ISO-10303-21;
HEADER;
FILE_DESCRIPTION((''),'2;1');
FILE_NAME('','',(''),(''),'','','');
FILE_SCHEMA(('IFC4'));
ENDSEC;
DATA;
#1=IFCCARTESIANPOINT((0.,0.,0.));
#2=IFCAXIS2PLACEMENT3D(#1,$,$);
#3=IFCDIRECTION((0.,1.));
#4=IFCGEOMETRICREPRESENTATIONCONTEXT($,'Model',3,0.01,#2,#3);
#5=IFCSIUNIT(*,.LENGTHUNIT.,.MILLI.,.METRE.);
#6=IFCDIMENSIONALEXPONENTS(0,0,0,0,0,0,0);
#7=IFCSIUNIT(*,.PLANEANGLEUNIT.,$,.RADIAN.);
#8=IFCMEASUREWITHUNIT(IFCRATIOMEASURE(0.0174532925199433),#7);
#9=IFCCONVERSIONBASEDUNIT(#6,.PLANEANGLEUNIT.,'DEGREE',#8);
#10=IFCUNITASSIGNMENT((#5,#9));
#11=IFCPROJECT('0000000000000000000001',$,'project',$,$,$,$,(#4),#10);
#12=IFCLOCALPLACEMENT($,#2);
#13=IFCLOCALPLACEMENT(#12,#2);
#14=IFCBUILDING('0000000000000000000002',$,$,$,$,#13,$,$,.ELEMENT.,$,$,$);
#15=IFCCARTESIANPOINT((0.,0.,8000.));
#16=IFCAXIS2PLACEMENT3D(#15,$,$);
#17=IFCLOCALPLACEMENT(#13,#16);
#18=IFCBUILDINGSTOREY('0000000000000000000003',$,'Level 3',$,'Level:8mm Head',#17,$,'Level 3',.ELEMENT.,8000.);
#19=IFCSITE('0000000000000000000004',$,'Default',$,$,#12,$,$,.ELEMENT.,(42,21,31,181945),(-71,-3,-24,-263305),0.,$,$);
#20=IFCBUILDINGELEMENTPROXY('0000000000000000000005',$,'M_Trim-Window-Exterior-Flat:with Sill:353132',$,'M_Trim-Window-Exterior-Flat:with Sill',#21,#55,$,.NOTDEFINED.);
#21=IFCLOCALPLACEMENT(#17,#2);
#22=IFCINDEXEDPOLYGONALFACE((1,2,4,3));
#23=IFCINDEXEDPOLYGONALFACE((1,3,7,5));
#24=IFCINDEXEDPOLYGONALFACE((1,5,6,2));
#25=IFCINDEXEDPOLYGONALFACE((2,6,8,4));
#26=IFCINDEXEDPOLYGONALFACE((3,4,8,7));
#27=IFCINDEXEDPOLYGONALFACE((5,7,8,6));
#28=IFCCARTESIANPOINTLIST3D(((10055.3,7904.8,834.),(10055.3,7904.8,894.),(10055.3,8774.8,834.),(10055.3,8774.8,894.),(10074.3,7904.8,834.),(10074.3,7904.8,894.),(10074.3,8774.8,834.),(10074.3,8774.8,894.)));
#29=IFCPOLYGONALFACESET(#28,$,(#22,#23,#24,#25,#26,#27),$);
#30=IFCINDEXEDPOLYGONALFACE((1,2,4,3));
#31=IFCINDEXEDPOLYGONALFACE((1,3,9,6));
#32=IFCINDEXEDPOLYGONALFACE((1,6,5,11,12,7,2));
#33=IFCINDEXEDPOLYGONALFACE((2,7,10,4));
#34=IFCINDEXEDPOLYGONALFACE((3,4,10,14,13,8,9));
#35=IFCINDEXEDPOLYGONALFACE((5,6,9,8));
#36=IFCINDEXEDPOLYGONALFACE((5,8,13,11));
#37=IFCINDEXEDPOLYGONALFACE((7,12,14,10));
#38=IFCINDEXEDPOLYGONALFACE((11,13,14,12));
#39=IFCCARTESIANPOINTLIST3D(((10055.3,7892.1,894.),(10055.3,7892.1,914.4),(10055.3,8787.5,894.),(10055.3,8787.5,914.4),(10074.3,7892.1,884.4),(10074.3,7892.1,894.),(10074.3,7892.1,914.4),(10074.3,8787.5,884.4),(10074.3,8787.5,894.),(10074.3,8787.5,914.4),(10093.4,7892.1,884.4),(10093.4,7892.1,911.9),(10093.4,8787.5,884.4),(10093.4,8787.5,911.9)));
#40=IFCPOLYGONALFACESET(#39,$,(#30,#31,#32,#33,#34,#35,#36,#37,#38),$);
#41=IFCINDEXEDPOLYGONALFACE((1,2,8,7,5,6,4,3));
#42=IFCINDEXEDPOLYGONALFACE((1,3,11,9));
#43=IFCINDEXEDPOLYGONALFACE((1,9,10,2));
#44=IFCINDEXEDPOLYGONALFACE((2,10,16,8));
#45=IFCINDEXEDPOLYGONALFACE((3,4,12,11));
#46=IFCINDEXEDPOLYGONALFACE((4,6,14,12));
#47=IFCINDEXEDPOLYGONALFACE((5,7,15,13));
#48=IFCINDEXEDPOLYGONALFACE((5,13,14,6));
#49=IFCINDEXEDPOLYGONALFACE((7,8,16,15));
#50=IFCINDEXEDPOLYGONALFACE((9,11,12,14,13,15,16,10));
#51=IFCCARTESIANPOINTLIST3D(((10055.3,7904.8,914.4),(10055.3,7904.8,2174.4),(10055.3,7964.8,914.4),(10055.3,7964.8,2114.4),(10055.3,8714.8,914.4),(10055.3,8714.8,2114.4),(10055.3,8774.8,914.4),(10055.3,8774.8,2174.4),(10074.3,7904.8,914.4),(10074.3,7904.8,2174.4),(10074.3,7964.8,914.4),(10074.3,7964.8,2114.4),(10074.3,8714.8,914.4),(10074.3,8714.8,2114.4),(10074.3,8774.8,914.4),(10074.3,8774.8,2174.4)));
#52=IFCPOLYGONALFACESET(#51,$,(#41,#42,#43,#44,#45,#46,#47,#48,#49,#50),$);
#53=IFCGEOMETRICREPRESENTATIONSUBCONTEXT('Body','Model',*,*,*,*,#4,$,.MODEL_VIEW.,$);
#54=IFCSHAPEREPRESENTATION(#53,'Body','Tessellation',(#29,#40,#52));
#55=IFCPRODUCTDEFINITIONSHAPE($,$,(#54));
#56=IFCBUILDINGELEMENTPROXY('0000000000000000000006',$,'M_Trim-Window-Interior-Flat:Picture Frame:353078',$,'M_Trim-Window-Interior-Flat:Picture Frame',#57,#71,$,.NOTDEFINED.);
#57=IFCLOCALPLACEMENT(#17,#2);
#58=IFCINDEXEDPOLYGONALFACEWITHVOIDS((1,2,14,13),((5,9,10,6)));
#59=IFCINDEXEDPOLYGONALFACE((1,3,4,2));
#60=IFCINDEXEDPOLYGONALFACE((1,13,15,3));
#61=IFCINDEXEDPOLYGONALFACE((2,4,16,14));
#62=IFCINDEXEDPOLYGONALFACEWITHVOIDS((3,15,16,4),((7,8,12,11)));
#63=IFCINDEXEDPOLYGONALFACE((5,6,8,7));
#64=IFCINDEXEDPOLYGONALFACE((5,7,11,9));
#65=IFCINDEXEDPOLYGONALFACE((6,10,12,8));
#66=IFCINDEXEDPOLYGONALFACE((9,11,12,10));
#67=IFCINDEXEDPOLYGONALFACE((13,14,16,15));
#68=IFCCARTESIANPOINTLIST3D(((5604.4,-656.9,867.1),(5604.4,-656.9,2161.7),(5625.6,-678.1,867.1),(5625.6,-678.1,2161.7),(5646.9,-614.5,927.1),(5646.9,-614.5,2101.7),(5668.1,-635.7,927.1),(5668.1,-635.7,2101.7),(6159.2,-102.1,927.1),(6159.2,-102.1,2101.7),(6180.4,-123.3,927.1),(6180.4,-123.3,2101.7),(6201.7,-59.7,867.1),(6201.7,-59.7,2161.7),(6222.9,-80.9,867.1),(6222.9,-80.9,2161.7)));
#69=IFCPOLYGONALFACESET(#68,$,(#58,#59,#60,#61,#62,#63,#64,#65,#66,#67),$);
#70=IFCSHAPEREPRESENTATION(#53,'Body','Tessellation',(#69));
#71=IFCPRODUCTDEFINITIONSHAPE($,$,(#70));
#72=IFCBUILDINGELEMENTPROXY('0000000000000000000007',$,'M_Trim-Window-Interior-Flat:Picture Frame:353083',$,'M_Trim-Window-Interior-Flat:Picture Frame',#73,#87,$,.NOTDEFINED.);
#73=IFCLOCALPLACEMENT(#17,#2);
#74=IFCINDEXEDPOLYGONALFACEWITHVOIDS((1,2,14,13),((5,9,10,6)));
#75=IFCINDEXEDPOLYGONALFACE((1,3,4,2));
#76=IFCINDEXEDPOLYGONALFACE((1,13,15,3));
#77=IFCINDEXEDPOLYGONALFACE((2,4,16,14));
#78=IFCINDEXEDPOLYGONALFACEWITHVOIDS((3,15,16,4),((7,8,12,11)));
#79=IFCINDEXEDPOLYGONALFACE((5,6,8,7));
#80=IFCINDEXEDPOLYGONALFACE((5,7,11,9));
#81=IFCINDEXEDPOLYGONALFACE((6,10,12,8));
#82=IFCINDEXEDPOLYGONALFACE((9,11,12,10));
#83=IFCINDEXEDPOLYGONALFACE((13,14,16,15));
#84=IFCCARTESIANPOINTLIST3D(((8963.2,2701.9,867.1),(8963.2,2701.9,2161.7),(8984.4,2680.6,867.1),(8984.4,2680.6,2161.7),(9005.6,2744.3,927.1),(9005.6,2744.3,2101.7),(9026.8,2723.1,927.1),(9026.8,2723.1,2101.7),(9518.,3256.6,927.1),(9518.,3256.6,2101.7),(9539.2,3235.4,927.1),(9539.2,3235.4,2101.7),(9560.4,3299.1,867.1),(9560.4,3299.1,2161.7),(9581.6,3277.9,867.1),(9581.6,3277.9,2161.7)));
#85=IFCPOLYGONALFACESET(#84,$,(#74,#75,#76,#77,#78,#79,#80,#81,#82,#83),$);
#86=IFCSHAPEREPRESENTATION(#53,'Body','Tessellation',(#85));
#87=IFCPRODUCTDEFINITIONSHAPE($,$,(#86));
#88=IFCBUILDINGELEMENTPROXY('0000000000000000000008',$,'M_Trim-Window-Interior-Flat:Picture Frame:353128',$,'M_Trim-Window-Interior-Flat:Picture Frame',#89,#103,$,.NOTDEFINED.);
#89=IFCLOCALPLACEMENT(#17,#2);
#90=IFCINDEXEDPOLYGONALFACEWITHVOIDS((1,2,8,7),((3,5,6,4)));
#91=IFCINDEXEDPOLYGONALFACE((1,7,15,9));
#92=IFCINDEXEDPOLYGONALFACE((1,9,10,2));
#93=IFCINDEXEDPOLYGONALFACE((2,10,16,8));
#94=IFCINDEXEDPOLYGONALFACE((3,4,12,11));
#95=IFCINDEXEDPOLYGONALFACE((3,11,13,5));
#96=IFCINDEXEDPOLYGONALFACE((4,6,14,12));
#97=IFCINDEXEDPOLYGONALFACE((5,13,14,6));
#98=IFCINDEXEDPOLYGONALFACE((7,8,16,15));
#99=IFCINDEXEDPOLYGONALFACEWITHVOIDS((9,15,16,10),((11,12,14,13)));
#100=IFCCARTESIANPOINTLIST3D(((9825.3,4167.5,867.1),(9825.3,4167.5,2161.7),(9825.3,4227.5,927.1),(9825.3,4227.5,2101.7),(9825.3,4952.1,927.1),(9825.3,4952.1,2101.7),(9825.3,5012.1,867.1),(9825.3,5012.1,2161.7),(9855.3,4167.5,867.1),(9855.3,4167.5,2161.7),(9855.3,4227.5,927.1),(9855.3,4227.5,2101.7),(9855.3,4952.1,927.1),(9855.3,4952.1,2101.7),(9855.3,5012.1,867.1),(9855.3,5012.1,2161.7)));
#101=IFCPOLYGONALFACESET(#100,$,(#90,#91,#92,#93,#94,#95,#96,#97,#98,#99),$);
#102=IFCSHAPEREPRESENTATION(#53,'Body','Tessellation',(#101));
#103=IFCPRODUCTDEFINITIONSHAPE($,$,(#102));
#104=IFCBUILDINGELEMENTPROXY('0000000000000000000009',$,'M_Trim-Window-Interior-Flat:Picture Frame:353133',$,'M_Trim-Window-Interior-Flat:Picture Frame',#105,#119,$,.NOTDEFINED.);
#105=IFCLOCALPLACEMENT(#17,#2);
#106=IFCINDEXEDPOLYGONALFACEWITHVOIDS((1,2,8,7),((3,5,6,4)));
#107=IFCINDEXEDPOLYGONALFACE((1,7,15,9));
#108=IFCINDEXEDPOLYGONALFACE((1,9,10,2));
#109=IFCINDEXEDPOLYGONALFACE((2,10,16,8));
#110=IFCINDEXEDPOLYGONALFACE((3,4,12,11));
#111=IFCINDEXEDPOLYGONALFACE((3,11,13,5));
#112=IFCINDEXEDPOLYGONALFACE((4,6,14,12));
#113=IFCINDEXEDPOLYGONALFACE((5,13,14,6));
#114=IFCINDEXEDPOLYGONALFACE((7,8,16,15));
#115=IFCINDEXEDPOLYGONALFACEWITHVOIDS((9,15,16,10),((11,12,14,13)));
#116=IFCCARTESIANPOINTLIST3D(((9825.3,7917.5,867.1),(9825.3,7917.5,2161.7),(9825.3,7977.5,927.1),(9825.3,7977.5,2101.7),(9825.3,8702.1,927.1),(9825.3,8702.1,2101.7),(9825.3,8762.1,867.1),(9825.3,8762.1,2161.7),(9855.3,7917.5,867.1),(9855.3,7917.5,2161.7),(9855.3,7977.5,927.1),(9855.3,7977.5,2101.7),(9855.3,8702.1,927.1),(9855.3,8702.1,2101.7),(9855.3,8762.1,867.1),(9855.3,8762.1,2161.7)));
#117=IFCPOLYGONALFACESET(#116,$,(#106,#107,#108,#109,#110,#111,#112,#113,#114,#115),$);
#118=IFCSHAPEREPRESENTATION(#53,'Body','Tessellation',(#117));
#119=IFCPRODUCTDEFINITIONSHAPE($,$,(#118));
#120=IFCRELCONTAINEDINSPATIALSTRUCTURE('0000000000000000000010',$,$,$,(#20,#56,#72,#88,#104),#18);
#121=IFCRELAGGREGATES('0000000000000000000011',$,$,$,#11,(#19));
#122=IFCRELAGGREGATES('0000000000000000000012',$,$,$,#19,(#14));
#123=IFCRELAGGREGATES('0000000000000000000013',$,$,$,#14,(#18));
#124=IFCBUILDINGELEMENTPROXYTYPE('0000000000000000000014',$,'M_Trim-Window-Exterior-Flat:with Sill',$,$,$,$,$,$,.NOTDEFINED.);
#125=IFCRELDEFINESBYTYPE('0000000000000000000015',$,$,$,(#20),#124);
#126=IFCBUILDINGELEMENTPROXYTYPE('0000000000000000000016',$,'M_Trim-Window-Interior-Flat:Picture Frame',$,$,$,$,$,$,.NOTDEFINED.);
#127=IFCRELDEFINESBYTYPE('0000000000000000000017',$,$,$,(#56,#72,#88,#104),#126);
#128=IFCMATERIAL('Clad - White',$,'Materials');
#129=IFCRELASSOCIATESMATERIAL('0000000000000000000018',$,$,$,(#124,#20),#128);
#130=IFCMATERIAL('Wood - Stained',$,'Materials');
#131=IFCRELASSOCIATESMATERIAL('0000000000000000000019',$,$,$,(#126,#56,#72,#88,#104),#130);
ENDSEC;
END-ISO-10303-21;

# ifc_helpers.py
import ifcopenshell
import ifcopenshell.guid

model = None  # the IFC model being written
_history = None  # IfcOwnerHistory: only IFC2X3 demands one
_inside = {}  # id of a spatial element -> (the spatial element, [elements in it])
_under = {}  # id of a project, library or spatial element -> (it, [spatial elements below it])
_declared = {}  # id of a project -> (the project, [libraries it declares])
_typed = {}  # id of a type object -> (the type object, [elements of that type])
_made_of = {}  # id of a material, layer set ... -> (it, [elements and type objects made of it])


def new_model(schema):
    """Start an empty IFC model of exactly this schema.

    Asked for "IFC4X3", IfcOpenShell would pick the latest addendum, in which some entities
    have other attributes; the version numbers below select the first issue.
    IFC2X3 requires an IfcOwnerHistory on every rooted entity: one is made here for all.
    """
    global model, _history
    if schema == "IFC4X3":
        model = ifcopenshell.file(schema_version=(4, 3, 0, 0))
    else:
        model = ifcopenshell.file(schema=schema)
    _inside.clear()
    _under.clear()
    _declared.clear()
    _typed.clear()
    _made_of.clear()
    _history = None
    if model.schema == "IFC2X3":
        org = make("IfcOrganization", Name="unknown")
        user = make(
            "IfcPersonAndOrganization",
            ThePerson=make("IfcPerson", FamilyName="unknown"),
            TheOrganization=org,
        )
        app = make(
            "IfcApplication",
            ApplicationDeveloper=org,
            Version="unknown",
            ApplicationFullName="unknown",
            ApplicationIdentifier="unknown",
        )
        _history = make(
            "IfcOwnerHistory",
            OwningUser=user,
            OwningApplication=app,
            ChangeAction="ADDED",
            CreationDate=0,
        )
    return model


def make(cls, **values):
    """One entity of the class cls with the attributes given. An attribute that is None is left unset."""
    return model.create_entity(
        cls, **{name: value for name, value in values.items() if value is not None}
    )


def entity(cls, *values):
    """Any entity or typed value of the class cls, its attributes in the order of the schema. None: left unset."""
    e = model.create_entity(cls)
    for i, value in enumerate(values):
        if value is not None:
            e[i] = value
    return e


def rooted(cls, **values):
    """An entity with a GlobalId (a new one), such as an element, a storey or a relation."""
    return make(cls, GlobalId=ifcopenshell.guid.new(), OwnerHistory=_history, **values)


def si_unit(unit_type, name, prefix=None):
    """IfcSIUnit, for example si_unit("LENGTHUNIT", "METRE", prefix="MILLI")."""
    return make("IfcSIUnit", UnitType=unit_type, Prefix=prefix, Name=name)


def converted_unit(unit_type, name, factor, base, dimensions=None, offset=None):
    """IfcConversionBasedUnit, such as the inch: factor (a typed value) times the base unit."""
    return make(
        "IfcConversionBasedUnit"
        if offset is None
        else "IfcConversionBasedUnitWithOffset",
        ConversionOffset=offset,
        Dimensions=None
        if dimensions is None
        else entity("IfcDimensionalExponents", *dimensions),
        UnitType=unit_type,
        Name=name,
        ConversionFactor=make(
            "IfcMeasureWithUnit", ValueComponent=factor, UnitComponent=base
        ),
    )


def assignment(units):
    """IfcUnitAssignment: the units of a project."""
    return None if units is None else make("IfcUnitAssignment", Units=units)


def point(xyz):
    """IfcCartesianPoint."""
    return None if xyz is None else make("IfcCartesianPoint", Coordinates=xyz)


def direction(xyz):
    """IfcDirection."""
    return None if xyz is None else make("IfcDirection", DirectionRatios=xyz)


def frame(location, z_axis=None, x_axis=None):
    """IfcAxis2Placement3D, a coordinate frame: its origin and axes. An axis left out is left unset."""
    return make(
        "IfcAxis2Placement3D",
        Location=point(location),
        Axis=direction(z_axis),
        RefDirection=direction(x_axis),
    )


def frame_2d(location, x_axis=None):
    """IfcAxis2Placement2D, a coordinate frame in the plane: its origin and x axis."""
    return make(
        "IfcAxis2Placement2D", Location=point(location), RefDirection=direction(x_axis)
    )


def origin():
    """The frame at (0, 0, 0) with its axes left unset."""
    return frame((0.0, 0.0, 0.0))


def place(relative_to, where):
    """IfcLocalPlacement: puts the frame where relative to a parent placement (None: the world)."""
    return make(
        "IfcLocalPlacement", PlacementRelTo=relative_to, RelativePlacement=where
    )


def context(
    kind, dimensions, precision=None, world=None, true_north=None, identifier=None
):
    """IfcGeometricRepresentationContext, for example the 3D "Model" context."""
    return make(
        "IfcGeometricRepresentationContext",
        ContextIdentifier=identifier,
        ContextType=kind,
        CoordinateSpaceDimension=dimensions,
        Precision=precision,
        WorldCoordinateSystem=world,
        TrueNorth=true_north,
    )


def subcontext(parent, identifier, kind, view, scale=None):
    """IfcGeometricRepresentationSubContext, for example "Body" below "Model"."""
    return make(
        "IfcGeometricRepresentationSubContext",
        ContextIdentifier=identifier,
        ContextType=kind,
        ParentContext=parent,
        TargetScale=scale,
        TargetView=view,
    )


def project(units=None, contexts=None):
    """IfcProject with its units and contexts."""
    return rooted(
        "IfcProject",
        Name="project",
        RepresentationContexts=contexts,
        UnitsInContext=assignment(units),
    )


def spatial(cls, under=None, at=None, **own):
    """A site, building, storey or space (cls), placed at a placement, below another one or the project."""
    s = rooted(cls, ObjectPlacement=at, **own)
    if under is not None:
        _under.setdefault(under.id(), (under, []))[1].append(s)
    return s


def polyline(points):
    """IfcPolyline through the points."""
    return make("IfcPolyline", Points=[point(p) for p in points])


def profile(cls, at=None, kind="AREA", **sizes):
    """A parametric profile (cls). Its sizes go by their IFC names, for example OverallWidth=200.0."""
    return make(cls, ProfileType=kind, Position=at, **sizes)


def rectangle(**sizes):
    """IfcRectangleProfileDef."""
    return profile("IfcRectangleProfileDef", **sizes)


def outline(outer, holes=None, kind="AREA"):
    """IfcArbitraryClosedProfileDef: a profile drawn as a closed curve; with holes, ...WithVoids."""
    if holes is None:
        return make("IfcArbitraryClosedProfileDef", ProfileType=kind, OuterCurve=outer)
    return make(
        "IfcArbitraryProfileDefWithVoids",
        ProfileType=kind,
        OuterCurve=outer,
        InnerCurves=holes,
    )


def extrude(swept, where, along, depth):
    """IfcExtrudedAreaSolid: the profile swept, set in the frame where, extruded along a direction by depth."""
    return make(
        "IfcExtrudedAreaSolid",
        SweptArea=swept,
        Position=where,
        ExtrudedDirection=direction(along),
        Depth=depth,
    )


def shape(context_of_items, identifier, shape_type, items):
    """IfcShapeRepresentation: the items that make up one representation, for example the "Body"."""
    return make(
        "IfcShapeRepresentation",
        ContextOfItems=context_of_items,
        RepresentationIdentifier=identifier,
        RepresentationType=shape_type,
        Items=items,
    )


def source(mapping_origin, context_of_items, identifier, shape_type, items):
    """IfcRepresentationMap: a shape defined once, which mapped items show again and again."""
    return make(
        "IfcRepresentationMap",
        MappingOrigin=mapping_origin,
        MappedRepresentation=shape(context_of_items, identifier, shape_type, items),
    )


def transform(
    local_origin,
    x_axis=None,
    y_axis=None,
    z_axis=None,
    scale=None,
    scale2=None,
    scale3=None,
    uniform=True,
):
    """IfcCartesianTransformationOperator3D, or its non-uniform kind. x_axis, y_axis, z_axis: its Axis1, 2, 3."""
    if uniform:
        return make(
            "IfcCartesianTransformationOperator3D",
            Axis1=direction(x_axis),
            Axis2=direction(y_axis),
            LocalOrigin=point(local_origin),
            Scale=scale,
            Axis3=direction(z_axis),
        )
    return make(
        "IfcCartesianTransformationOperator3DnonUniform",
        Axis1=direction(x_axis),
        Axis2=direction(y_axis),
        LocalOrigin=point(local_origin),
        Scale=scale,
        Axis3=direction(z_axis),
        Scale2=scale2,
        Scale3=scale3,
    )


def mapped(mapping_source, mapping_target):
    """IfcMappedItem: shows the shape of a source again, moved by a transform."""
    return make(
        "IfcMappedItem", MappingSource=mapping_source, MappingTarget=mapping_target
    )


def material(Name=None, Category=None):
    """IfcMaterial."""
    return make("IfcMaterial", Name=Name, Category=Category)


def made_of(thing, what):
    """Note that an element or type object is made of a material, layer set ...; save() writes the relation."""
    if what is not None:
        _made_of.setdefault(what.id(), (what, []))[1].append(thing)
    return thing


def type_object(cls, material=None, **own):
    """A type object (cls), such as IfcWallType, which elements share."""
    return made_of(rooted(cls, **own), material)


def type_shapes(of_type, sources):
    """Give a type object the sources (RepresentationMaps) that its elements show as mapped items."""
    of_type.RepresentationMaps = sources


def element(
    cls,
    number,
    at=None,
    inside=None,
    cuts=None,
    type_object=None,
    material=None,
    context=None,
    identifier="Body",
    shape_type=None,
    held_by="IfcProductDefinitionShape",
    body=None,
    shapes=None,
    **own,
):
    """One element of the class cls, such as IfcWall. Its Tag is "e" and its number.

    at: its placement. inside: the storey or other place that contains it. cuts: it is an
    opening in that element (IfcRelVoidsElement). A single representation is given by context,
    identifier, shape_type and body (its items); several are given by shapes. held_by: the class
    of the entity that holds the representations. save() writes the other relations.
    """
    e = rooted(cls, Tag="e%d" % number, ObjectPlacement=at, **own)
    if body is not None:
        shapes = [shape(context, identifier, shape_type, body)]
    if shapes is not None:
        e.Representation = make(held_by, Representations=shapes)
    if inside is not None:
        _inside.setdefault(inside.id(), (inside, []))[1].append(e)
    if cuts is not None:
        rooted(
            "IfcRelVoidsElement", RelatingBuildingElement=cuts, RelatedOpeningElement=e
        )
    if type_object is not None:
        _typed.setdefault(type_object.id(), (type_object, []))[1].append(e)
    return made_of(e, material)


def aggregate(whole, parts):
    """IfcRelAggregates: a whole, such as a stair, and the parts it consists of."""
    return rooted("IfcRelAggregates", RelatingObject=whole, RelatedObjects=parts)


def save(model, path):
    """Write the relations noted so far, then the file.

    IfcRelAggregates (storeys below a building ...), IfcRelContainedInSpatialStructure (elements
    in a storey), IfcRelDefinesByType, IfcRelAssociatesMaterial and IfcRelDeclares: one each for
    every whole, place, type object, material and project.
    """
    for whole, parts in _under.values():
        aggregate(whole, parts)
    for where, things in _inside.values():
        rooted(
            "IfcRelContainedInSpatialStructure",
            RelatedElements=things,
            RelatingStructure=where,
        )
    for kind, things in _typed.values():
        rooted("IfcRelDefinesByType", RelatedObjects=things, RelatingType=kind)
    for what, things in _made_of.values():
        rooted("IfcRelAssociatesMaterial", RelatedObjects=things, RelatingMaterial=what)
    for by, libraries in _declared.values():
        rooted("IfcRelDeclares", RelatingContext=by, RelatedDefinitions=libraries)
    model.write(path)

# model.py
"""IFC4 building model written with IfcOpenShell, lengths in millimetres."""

from ifc_helpers import new_model, entity, si_unit, converted_unit, direction, frame, frame_2d, origin, place, context, subcontext, project, spatial, polyline, rectangle, outline, extrude, source, transform, mapped, material, type_object, type_shapes, element, save


model = new_model("IFC4")

# Units and contexts
model_context = context("Model", 3, precision=0.01, world=origin(), true_north=direction((0.0, 1.0)))
body_context = subcontext(model_context, "Body", "Model", "MODEL_VIEW")
ifc_project = project(units=[si_unit("LENGTHUNIT", "METRE", prefix="MILLI"), converted_unit("PLANEANGLEUNIT", "DEGREE", entity("IfcRatioMeasure", 0.0174532925199433), si_unit("PLANEANGLEUNIT", "RADIAN"), dimensions=[0, 0, 0, 0, 0, 0, 0])], contexts=[model_context])

# Site, building, storey
site_placement = place(None, origin())
site = spatial("IfcSite", under=ifc_project, at=site_placement, Name="Default", CompositionType="ELEMENT", RefLatitude=(42, 21, 31, 181945), RefLongitude=(-71, -3, -24, -263305), RefElevation=0.0)
building_placement = place(site_placement, origin())
building = spatial("IfcBuilding", under=site, at=building_placement, CompositionType="ELEMENT")
storey_placement = place(building_placement, frame((0.0, 0.0, 8000.0)))
storey = spatial("IfcBuildingStorey", under=building, at=storey_placement, Name="Level 3", ObjectType="Level:8mm Head", LongName="Level 3", CompositionType="ELEMENT", Elevation=8000.0)

# Shared definitions
ifc_material_1 = material(Name="Wood - Stained", Category="Materials")

# Building element proxies
ifc_material_2 = material(Name="Clad - White", Category="Materials")
building_element_proxy_type_1 = type_object("IfcBuildingElementProxyType", Name="M_Trim-Window-Exterior-Flat:with Sill", PredefinedType="NOTDEFINED", material=ifc_material_2)
shared_shape_1 = source(origin(), body_context, "Body", "SweptSolid", [
    extrude(rectangle(XDim=870.0, YDim=60.0, at=frame_2d((0.0, 0.0), x_axis=(1.0, 0.0))), frame((0.0, -1250.4, 0.0), z_axis=(0.0, 0.0, 1.0), x_axis=(-1.0, 0.0, 0.0)), (0.0, 0.0, 1.0), 19.1),
    extrude(outline(polyline([(-19.0, -15.2), (0.0, -15.2), (0.0, -5.7), (19.0, -5.7), (19.0, 14.8), (0.0, 14.8), (-19.0, 12.3), (-19.0, -15.2)])), frame((-447.7, -1214.8, 19.0), z_axis=(1.0, 0.0, 0.0), x_axis=(0.0, 0.0, -1.0)), (0.0, 0.0, 1.0), 895.4),
    extrude(outline(polyline([(-645.0, -435.0), (615.0, -435.0), (615.0, -375.0), (-585.0, -375.0), (-585.0, 375.0), (615.0, 375.0), (615.0, 435.0), (-645.0, 435.0), (-645.0, -435.0)])), frame((0.0, -585.0, 0.0), z_axis=(0.0, 0.0, 1.0), x_axis=(0.0, -1.0, 0.0)), (0.0, 0.0, 1.0), 19.1),
])
type_shapes(building_element_proxy_type_1, [shared_shape_1])
for number, where, z_axis, x_axis, name in (
    (1, (10055.3, 8339.8, 2114.4), (1.0, 0.0, 0.0), (0.0, 1.0, 0.0), "M_Trim-Window-Exterior-Flat:with Sill:353132"),
):
    element("IfcBuildingElementProxy", number, at=place(storey_placement, frame(where, z_axis=z_axis, x_axis=x_axis)), inside=storey, type_object=building_element_proxy_type_1, material=ifc_material_2, Name=name, ObjectType="M_Trim-Window-Exterior-Flat:with Sill", PredefinedType="NOTDEFINED", context=body_context, shape_type="MappedRepresentation", body=[
        mapped(shared_shape_1, transform((0.0, 0.0, 0.0), scale=1.0)),
    ])
building_element_proxy_type_2 = type_object("IfcBuildingElementProxyType", Name="M_Trim-Window-Interior-Flat:Picture Frame", PredefinedType="NOTDEFINED", material=ifc_material_1)
shared_shape_2 = source(origin(), body_context, "Body", "SweptSolid", [
    extrude(outline(polyline([(-422.3, -647.3), (422.3, -647.3), (422.3, 647.3), (-422.3, 647.3), (-422.3, -647.3)]), holes=[polyline([(-362.3, -587.3), (-362.3, 587.3), (362.3, 587.3), (362.3, -587.3), (-362.3, -587.3)])]), frame((0.0, -600.0, 0.0), z_axis=(0.0, 0.0, 1.0), x_axis=(-1.0, 0.0, 0.0)), (0.0, 0.0, 1.0), 30.0),
])
type_shapes(building_element_proxy_type_2, [shared_shape_2])
for number, where, z_axis, x_axis, name in (
    (2, (5903.0, -358.3, 2114.4), (0.707107, -0.707107, 0.0), (0.707107, 0.707107, 0.0), "M_Trim-Window-Interior-Flat:Picture Frame:353078"),
    (3, (9261.8, 3000.5, 2114.4), (0.707107, -0.707107, 0.0), (0.707107, 0.707107, 0.0), "M_Trim-Window-Interior-Flat:Picture Frame:353083"),
    (4, (9855.3, 4589.8, 2114.4), (-1.0, 0.0, 0.0), (0.0, -1.0, 0.0), "M_Trim-Window-Interior-Flat:Picture Frame:353128"),
    (5, (9855.3, 8339.8, 2114.4), (-1.0, 0.0, 0.0), (0.0, -1.0, 0.0), "M_Trim-Window-Interior-Flat:Picture Frame:353133"),
):
    element("IfcBuildingElementProxy", number, at=place(storey_placement, frame(where, z_axis=z_axis, x_axis=x_axis)), inside=storey, type_object=building_element_proxy_type_2, material=ifc_material_1, Name=name, ObjectType="M_Trim-Window-Interior-Flat:Picture Frame", PredefinedType="NOTDEFINED", context=body_context, shape_type="MappedRepresentation", body=[
        mapped(shared_shape_2, transform((0.0, 0.0, 0.0), scale=1.0)),
    ])

save(model, "model.ifc")
